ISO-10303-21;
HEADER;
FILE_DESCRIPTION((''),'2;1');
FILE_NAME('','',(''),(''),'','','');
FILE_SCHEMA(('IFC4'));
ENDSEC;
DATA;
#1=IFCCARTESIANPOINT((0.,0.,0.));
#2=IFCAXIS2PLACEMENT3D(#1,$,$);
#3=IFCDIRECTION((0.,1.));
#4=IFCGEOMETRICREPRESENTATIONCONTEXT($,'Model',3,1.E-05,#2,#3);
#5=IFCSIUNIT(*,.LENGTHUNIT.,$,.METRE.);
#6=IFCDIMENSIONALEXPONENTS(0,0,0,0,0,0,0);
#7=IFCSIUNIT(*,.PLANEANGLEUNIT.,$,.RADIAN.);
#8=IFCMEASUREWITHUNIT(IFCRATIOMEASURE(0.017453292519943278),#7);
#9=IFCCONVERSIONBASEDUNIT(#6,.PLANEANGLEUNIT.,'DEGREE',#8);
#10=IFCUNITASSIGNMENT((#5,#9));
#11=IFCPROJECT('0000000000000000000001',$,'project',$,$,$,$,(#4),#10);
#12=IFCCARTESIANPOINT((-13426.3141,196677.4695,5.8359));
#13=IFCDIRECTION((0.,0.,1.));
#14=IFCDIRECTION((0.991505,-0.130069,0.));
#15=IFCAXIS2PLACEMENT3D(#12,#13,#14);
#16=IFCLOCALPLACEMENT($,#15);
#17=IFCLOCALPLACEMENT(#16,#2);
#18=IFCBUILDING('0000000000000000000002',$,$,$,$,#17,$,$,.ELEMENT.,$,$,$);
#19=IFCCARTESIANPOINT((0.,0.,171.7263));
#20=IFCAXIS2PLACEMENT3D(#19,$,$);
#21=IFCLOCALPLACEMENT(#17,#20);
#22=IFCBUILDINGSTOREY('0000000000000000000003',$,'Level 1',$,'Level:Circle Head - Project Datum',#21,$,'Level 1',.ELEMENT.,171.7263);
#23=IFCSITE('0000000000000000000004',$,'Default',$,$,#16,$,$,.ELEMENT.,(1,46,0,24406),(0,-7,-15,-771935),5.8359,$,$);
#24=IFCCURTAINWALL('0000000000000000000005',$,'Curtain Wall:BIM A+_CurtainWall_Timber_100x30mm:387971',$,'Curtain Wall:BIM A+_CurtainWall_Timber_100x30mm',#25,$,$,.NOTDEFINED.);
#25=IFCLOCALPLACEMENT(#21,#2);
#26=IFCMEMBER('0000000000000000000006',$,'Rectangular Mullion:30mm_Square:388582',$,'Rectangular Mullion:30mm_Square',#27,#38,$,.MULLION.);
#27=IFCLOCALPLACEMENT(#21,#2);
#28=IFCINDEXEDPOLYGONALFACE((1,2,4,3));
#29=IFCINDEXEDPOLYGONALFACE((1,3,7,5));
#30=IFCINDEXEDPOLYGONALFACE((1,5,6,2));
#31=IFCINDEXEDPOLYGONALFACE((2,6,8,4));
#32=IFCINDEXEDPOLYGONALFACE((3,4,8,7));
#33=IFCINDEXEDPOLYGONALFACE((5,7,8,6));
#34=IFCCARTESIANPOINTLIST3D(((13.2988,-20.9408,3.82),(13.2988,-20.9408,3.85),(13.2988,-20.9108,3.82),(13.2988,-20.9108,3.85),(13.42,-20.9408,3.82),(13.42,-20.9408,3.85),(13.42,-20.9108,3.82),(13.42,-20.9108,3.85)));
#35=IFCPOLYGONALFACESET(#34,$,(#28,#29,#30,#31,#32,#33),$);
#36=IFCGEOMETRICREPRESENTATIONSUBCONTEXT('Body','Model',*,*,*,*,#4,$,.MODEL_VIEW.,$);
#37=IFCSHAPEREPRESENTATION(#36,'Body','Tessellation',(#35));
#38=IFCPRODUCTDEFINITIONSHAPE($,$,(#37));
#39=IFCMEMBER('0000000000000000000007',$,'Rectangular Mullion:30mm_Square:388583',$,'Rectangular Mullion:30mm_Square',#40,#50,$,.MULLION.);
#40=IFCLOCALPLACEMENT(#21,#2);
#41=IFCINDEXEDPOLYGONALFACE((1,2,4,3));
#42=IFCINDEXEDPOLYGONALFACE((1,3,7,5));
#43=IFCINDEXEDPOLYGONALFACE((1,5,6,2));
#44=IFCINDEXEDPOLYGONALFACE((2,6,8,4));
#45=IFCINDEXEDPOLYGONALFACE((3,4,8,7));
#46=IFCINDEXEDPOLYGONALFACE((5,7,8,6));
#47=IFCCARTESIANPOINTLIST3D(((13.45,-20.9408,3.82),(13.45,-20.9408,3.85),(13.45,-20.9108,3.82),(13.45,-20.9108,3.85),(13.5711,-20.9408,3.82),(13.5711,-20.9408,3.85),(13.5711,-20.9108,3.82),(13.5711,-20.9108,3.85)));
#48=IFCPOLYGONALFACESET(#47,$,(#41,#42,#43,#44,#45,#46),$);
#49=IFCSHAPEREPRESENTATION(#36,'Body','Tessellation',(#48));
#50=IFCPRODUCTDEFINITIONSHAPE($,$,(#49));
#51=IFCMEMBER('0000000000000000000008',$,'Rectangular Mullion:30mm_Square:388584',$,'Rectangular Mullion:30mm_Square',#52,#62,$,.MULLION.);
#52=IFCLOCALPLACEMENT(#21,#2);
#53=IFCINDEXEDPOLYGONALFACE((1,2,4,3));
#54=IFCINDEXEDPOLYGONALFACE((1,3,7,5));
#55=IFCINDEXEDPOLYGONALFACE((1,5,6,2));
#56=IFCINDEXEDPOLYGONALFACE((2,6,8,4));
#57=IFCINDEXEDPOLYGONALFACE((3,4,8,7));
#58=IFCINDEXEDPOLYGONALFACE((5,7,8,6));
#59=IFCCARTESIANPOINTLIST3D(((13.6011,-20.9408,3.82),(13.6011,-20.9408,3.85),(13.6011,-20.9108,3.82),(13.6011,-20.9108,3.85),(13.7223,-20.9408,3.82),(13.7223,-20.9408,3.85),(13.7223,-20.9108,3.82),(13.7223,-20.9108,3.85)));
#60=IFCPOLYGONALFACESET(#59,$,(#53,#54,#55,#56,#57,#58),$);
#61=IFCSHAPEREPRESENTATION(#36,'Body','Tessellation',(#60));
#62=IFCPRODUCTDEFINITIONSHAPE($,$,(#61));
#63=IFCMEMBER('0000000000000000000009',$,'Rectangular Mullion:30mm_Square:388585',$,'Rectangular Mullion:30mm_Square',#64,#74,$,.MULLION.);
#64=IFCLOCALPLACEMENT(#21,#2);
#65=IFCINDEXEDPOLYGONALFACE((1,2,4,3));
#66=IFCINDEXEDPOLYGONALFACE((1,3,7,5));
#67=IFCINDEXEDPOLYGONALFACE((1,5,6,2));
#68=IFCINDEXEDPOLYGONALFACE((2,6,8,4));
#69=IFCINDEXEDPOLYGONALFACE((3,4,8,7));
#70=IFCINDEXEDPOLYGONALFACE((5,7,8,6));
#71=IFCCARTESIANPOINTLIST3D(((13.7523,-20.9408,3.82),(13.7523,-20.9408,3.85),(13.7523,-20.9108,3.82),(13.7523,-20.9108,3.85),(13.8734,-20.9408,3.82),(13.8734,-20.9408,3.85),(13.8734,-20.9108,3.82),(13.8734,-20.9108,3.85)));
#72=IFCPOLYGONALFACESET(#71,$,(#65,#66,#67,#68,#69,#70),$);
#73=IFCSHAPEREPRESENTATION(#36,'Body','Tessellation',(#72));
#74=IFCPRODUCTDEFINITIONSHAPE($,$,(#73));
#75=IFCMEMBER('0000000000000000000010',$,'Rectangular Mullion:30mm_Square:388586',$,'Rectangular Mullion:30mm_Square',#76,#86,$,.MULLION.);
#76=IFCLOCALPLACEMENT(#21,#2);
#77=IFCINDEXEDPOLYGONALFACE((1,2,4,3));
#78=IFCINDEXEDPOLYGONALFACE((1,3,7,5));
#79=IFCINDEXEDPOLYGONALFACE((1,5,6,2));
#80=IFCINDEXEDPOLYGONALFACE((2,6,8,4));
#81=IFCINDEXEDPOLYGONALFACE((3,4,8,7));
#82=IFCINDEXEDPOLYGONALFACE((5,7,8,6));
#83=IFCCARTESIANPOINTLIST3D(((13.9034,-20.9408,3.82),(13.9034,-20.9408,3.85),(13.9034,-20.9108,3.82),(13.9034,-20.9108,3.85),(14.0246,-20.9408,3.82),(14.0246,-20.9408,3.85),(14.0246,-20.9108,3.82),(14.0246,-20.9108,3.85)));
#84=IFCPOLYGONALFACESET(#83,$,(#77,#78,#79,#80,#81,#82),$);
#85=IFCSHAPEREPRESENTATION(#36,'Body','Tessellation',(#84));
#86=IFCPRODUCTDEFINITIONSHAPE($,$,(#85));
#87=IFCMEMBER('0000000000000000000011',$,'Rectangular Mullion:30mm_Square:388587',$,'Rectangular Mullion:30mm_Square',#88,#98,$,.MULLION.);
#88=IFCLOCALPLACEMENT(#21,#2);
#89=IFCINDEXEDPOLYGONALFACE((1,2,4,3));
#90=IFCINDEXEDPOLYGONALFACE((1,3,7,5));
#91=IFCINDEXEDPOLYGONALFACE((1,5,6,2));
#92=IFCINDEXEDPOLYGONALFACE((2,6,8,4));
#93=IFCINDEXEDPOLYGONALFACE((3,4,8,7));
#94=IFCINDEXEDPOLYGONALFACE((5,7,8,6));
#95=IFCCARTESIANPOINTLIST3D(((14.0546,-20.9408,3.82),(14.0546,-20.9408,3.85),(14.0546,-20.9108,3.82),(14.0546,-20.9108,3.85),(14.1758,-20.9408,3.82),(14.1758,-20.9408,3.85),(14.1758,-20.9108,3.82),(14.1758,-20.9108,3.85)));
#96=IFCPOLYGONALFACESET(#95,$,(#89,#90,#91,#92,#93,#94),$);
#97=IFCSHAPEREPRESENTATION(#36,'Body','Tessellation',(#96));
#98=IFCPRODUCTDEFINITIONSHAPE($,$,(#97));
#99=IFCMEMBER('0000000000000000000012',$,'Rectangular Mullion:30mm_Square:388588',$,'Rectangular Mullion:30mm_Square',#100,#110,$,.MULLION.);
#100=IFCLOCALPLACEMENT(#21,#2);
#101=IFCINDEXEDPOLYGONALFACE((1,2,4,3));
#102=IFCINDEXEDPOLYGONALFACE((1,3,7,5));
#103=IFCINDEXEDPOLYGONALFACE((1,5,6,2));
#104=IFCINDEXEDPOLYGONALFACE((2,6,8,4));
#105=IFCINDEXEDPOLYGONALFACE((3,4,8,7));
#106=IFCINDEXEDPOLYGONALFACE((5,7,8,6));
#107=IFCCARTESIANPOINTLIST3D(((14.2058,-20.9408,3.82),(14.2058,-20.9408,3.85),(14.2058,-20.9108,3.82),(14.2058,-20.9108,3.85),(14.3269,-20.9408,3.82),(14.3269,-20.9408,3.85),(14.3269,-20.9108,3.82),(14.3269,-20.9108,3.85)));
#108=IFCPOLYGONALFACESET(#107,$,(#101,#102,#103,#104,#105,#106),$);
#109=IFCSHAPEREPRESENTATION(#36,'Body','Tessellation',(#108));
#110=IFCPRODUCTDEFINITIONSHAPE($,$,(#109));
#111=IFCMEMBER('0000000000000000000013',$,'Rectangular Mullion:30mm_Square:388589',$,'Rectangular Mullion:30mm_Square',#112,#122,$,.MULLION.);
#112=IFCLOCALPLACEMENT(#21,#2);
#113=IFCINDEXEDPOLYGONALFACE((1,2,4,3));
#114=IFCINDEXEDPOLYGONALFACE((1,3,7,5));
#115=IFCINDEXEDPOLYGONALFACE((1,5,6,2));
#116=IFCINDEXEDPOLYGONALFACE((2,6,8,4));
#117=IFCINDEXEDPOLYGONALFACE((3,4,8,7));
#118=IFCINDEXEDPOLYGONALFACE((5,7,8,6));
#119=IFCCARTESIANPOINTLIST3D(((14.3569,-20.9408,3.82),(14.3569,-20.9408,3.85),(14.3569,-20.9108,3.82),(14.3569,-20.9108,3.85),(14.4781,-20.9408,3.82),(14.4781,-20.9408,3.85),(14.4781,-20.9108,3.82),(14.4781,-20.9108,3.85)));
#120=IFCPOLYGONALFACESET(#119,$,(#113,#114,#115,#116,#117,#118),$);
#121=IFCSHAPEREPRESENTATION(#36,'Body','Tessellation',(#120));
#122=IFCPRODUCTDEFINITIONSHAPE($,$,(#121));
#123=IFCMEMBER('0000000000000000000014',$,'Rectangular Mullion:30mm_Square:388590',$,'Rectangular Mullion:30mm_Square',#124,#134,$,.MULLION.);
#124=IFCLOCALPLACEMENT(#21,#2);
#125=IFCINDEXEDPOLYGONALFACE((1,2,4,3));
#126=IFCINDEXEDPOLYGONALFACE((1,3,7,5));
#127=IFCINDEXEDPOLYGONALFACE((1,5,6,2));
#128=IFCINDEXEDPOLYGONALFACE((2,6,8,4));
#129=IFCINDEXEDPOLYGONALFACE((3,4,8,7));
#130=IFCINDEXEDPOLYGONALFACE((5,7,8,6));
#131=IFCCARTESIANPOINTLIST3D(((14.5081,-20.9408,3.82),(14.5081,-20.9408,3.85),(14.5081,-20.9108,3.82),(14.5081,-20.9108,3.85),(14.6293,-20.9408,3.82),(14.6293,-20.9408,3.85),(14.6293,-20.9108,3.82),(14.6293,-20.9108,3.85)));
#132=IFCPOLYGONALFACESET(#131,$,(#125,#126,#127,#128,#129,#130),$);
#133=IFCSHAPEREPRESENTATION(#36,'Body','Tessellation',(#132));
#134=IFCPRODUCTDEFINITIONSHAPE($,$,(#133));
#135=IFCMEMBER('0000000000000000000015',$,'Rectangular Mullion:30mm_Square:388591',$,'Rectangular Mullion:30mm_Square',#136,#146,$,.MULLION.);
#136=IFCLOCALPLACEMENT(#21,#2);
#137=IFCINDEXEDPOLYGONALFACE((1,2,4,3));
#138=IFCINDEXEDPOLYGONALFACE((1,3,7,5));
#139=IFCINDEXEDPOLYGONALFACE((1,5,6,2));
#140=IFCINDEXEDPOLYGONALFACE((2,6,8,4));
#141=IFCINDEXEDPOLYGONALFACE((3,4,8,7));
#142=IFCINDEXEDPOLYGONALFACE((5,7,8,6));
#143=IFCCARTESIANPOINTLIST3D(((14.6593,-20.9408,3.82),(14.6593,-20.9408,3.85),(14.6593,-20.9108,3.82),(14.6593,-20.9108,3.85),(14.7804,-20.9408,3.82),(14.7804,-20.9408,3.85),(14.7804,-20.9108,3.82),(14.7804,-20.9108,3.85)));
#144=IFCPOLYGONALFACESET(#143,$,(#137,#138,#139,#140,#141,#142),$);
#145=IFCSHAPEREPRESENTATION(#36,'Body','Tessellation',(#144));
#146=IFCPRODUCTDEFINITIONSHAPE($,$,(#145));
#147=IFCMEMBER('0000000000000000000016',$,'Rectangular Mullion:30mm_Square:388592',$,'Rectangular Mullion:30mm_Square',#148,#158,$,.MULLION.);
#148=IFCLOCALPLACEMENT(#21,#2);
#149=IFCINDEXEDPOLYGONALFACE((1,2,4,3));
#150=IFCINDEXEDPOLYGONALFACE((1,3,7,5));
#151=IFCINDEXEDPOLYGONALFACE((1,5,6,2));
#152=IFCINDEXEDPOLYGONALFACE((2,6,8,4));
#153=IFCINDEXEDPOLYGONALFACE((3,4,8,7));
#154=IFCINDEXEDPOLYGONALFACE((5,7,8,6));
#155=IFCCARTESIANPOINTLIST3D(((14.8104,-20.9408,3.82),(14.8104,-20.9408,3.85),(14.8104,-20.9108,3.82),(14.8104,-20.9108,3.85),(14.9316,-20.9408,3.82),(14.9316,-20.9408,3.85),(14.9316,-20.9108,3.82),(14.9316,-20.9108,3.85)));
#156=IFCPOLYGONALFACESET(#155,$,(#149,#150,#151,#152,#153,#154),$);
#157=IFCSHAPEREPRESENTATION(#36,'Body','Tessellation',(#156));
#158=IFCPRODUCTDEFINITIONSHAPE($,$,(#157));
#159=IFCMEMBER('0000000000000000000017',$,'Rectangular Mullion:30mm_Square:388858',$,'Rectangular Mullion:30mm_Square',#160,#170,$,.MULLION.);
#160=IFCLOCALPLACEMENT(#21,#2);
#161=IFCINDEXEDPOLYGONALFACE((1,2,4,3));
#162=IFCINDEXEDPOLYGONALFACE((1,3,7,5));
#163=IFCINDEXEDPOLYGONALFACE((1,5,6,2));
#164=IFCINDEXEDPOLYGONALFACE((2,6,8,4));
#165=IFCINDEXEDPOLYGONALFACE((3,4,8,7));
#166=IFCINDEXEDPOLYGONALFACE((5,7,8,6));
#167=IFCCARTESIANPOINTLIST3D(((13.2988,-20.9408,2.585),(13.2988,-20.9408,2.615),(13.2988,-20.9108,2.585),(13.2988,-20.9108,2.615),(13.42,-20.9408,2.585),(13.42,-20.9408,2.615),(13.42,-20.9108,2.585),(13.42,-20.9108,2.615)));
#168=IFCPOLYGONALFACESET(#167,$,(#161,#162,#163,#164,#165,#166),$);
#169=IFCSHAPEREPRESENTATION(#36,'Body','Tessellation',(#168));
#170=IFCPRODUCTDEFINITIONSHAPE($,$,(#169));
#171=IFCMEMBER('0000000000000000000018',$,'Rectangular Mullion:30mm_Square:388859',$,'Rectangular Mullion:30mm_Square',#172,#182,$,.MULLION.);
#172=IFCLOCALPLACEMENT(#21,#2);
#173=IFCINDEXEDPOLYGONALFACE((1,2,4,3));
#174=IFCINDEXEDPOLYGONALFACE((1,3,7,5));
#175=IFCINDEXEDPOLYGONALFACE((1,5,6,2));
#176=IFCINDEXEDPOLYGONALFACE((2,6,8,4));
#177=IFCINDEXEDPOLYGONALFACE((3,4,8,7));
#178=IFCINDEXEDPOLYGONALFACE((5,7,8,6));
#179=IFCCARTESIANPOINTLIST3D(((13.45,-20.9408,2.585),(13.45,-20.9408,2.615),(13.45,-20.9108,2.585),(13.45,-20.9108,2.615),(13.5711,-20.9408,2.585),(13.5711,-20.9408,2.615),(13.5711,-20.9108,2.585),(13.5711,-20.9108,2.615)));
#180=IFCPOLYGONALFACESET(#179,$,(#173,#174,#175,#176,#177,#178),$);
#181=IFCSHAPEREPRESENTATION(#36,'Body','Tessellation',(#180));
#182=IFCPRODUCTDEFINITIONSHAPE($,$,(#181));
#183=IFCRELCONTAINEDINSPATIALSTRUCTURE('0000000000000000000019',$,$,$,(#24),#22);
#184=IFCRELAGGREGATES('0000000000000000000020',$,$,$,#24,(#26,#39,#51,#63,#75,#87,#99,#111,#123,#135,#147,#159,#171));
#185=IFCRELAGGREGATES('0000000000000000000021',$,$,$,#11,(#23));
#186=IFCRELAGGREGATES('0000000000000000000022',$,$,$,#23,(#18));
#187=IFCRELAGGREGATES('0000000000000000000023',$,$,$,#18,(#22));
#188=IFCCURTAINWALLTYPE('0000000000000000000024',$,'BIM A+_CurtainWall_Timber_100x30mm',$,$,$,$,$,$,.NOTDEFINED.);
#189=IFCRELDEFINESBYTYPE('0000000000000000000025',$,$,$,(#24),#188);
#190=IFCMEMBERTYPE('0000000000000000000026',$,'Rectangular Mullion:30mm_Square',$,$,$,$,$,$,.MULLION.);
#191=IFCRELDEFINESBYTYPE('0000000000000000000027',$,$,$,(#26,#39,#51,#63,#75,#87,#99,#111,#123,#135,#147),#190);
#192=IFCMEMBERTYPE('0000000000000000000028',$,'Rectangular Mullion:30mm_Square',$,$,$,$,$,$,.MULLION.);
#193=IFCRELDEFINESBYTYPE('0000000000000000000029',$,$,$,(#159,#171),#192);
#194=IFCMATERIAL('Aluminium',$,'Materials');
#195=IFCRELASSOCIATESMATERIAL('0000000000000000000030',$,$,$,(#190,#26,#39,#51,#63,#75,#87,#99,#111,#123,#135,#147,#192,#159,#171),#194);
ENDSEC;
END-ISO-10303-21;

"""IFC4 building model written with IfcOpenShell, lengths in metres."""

from ifc_helpers import new_model, entity, si_unit, converted_unit, direction, frame, origin, place, context, subcontext, project, spatial, indexed_curve, outline, extrude, source, transform, mapped, material, type_object, type_shapes, element, aggregate, save


model = new_model("IFC4")

# Units and contexts
model_context = context("Model", 3, precision=1e-05, world=origin(), true_north=direction((0.0, 1.0)))
body_context = subcontext(model_context, "Body", "Model", "MODEL_VIEW")
ifc_project = project(units=[si_unit("LENGTHUNIT", "METRE"), converted_unit("PLANEANGLEUNIT", "DEGREE", entity("IfcRatioMeasure", 0.017453292519943278), si_unit("PLANEANGLEUNIT", "RADIAN"), dimensions=[0, 0, 0, 0, 0, 0, 0])], contexts=[model_context])

# Site, building, storey
site_placement = place(None, frame((-13426.3141, 196677.4695, 5.8359), z_axis=(0.0, 0.0, 1.0), x_axis=(0.991505, -0.130069, 0.0)))
site = spatial("IfcSite", under=ifc_project, at=site_placement, Name="Default", CompositionType="ELEMENT", RefLatitude=(1, 46, 0, 24406), RefLongitude=(0, -7, -15, -771935), RefElevation=5.8359)
building_placement = place(site_placement, origin())
building = spatial("IfcBuilding", under=site, at=building_placement, CompositionType="ELEMENT")
storey_placement = place(building_placement, frame((0.0, 0.0, 171.7263)))
storey = spatial("IfcBuildingStorey", under=building, at=storey_placement, Name="Level 1", ObjectType="Level:Circle Head - Project Datum", LongName="Level 1", CompositionType="ELEMENT", Elevation=171.7263)

# Curtain wall, members
curtain_wall_type = type_object("IfcCurtainWallType", Name="BIM A+_CurtainWall_Timber_100x30mm", PredefinedType="NOTDEFINED")
curtain_wall_placement = place(storey_placement, frame((0.0, 0.0, -171.7263)))
curtain_wall = element("IfcCurtainWall", 1, at=curtain_wall_placement, inside=storey, type_object=curtain_wall_type, Name="Curtain Wall:BIM A+_CurtainWall_Timber_100x30mm:387971", ObjectType="Curtain Wall:BIM A+_CurtainWall_Timber_100x30mm", PredefinedType="NOTDEFINED")
ifc_material_1 = material(Name="Aluminium", Category="Materials")
member_type_1 = type_object("IfcMemberType", Name="Rectangular Mullion:30mm_Square", PredefinedType="MULLION", material=ifc_material_1)
shared_shape_1 = source(origin(), body_context, "Body", "SweptSolid", [
    extrude(outline(indexed_curve([(-0.015, -0.015), (0.015, -0.015), (0.015, 0.015), (-0.015, 0.015), (-0.015, -0.015)], self_intersect=False)), frame((-0.015, 0.0, -0.1212), z_axis=(0.0, 0.0, 1.0), x_axis=(0.0, -1.0, 0.0)), (0.0, 0.0, 1.0), 0.1212),
])
type_shapes(member_type_1, [shared_shape_1])
member_1_placement = place(curtain_wall_placement, frame((13.42, -20.9258, 175.5763), z_axis=(1.0, 0.0, 0.0), x_axis=(0.0, 0.0, 1.0)))
member_1 = element("IfcMember", 2, at=member_1_placement, type_object=member_type_1, material=ifc_material_1, Name="Rectangular Mullion:30mm_Square:388582", ObjectType="Rectangular Mullion:30mm_Square", PredefinedType="MULLION", context=body_context, shape_type="MappedRepresentation", body=[
    mapped(shared_shape_1, transform((0.0, 0.0, 0.0), scale=1.0)),
])
member_2_placement = place(curtain_wall_placement, frame((13.5711, -20.9258, 175.5763), z_axis=(1.0, 0.0, 0.0), x_axis=(0.0, 0.0, 1.0)))
member_2 = element("IfcMember", 3, at=member_2_placement, type_object=member_type_1, material=ifc_material_1, Name="Rectangular Mullion:30mm_Square:388583", ObjectType="Rectangular Mullion:30mm_Square", PredefinedType="MULLION", context=body_context, shape_type="MappedRepresentation", body=[
    mapped(shared_shape_1, transform((0.0, 0.0, 0.0), scale=1.0)),
])
member_3_placement = place(curtain_wall_placement, frame((13.7223, -20.9258, 175.5763), z_axis=(1.0, 0.0, 0.0), x_axis=(0.0, 0.0, 1.0)))
member_3 = element("IfcMember", 4, at=member_3_placement, type_object=member_type_1, material=ifc_material_1, Name="Rectangular Mullion:30mm_Square:388584", ObjectType="Rectangular Mullion:30mm_Square", PredefinedType="MULLION", context=body_context, shape_type="MappedRepresentation", body=[
    mapped(shared_shape_1, transform((0.0, 0.0, 0.0), scale=1.0)),
])
member_4_placement = place(curtain_wall_placement, frame((13.8734, -20.9258, 175.5763), z_axis=(1.0, 0.0, 0.0), x_axis=(0.0, 0.0, 1.0)))
member_4 = element("IfcMember", 5, at=member_4_placement, type_object=member_type_1, material=ifc_material_1, Name="Rectangular Mullion:30mm_Square:388585", ObjectType="Rectangular Mullion:30mm_Square", PredefinedType="MULLION", context=body_context, shape_type="MappedRepresentation", body=[
    mapped(shared_shape_1, transform((0.0, 0.0, 0.0), scale=1.0)),
])
member_5_placement = place(curtain_wall_placement, frame((14.0246, -20.9258, 175.5763), z_axis=(1.0, 0.0, 0.0), x_axis=(0.0, 0.0, 1.0)))
member_5 = element("IfcMember", 6, at=member_5_placement, type_object=member_type_1, material=ifc_material_1, Name="Rectangular Mullion:30mm_Square:388586", ObjectType="Rectangular Mullion:30mm_Square", PredefinedType="MULLION", context=body_context, shape_type="MappedRepresentation", body=[
    mapped(shared_shape_1, transform((0.0, 0.0, 0.0), scale=1.0)),
])
member_6_placement = place(curtain_wall_placement, frame((14.1758, -20.9258, 175.5763), z_axis=(1.0, 0.0, 0.0), x_axis=(0.0, 0.0, 1.0)))
member_6 = element("IfcMember", 7, at=member_6_placement, type_object=member_type_1, material=ifc_material_1, Name="Rectangular Mullion:30mm_Square:388587", ObjectType="Rectangular Mullion:30mm_Square", PredefinedType="MULLION", context=body_context, shape_type="MappedRepresentation", body=[
    mapped(shared_shape_1, transform((0.0, 0.0, 0.0), scale=1.0)),
])
member_7_placement = place(curtain_wall_placement, frame((14.3269, -20.9258, 175.5763), z_axis=(1.0, 0.0, 0.0), x_axis=(0.0, 0.0, 1.0)))
member_7 = element("IfcMember", 8, at=member_7_placement, type_object=member_type_1, material=ifc_material_1, Name="Rectangular Mullion:30mm_Square:388588", ObjectType="Rectangular Mullion:30mm_Square", PredefinedType="MULLION", context=body_context, shape_type="MappedRepresentation", body=[
    mapped(shared_shape_1, transform((0.0, 0.0, 0.0), scale=1.0)),
])
member_8_placement = place(curtain_wall_placement, frame((14.4781, -20.9258, 175.5763), z_axis=(1.0, 0.0, 0.0), x_axis=(0.0, 0.0, 1.0)))
member_8 = element("IfcMember", 9, at=member_8_placement, type_object=member_type_1, material=ifc_material_1, Name="Rectangular Mullion:30mm_Square:388589", ObjectType="Rectangular Mullion:30mm_Square", PredefinedType="MULLION", context=body_context, shape_type="MappedRepresentation", body=[
    mapped(shared_shape_1, transform((0.0, 0.0, 0.0), scale=1.0)),
])
member_9_placement = place(curtain_wall_placement, frame((14.6293, -20.9258, 175.5763), z_axis=(1.0, 0.0, 0.0), x_axis=(0.0, 0.0, 1.0)))
member_9 = element("IfcMember", 10, at=member_9_placement, type_object=member_type_1, material=ifc_material_1, Name="Rectangular Mullion:30mm_Square:388590", ObjectType="Rectangular Mullion:30mm_Square", PredefinedType="MULLION", context=body_context, shape_type="MappedRepresentation", body=[
    mapped(shared_shape_1, transform((0.0, 0.0, 0.0), scale=1.0)),
])
member_10_placement = place(curtain_wall_placement, frame((14.7804, -20.9258, 175.5763), z_axis=(1.0, 0.0, 0.0), x_axis=(0.0, 0.0, 1.0)))
member_10 = element("IfcMember", 11, at=member_10_placement, type_object=member_type_1, material=ifc_material_1, Name="Rectangular Mullion:30mm_Square:388591", ObjectType="Rectangular Mullion:30mm_Square", PredefinedType="MULLION", context=body_context, shape_type="MappedRepresentation", body=[
    mapped(shared_shape_1, transform((0.0, 0.0, 0.0), scale=1.0)),
])
member_11_placement = place(curtain_wall_placement, frame((14.9316, -20.9258, 175.5763), z_axis=(1.0, 0.0, 0.0), x_axis=(0.0, 0.0, 1.0)))
member_11 = element("IfcMember", 12, at=member_11_placement, type_object=member_type_1, material=ifc_material_1, Name="Rectangular Mullion:30mm_Square:388592", ObjectType="Rectangular Mullion:30mm_Square", PredefinedType="MULLION", context=body_context, shape_type="MappedRepresentation", body=[
    mapped(shared_shape_1, transform((0.0, 0.0, 0.0), scale=1.0)),
])
member_type_2 = type_object("IfcMemberType", Name="Rectangular Mullion:30mm_Square", PredefinedType="MULLION", material=ifc_material_1)
shared_shape_2 = source(origin(), body_context, "Body", "SweptSolid", [
    extrude(outline(indexed_curve([(-0.015, -0.015), (0.015, -0.015), (0.015, 0.015), (-0.015, 0.015), (-0.015, -0.015)], self_intersect=False)), frame((0.0, 0.0, -0.1212), z_axis=(0.0, 0.0, 1.0), x_axis=(0.0, -1.0, 0.0)), (0.0, 0.0, 1.0), 0.1212),
])
type_shapes(member_type_2, [shared_shape_2])
member_12_placement = place(curtain_wall_placement, frame((13.42, -20.9258, 174.3263), z_axis=(1.0, 0.0, 0.0), x_axis=(0.0, 0.0, 1.0)))
member_12 = element("IfcMember", 13, at=member_12_placement, type_object=member_type_2, material=ifc_material_1, Name="Rectangular Mullion:30mm_Square:388858", ObjectType="Rectangular Mullion:30mm_Square", PredefinedType="MULLION", context=body_context, shape_type="MappedRepresentation", body=[
    mapped(shared_shape_2, transform((0.0, 0.0, 0.0), scale=1.0)),
])
member_13_placement = place(curtain_wall_placement, frame((13.5711, -20.9258, 174.3263), z_axis=(1.0, 0.0, 0.0), x_axis=(0.0, 0.0, 1.0)))
member_13 = element("IfcMember", 14, at=member_13_placement, type_object=member_type_2, material=ifc_material_1, Name="Rectangular Mullion:30mm_Square:388859", ObjectType="Rectangular Mullion:30mm_Square", PredefinedType="MULLION", context=body_context, shape_type="MappedRepresentation", body=[
    mapped(shared_shape_2, transform((0.0, 0.0, 0.0), scale=1.0)),
])
aggregate(curtain_wall, [member_1, member_2, member_3, member_4, member_5, member_6, member_7, member_8, member_9, member_10, member_11, member_12, member_13])

save(model, "model.ifc")
